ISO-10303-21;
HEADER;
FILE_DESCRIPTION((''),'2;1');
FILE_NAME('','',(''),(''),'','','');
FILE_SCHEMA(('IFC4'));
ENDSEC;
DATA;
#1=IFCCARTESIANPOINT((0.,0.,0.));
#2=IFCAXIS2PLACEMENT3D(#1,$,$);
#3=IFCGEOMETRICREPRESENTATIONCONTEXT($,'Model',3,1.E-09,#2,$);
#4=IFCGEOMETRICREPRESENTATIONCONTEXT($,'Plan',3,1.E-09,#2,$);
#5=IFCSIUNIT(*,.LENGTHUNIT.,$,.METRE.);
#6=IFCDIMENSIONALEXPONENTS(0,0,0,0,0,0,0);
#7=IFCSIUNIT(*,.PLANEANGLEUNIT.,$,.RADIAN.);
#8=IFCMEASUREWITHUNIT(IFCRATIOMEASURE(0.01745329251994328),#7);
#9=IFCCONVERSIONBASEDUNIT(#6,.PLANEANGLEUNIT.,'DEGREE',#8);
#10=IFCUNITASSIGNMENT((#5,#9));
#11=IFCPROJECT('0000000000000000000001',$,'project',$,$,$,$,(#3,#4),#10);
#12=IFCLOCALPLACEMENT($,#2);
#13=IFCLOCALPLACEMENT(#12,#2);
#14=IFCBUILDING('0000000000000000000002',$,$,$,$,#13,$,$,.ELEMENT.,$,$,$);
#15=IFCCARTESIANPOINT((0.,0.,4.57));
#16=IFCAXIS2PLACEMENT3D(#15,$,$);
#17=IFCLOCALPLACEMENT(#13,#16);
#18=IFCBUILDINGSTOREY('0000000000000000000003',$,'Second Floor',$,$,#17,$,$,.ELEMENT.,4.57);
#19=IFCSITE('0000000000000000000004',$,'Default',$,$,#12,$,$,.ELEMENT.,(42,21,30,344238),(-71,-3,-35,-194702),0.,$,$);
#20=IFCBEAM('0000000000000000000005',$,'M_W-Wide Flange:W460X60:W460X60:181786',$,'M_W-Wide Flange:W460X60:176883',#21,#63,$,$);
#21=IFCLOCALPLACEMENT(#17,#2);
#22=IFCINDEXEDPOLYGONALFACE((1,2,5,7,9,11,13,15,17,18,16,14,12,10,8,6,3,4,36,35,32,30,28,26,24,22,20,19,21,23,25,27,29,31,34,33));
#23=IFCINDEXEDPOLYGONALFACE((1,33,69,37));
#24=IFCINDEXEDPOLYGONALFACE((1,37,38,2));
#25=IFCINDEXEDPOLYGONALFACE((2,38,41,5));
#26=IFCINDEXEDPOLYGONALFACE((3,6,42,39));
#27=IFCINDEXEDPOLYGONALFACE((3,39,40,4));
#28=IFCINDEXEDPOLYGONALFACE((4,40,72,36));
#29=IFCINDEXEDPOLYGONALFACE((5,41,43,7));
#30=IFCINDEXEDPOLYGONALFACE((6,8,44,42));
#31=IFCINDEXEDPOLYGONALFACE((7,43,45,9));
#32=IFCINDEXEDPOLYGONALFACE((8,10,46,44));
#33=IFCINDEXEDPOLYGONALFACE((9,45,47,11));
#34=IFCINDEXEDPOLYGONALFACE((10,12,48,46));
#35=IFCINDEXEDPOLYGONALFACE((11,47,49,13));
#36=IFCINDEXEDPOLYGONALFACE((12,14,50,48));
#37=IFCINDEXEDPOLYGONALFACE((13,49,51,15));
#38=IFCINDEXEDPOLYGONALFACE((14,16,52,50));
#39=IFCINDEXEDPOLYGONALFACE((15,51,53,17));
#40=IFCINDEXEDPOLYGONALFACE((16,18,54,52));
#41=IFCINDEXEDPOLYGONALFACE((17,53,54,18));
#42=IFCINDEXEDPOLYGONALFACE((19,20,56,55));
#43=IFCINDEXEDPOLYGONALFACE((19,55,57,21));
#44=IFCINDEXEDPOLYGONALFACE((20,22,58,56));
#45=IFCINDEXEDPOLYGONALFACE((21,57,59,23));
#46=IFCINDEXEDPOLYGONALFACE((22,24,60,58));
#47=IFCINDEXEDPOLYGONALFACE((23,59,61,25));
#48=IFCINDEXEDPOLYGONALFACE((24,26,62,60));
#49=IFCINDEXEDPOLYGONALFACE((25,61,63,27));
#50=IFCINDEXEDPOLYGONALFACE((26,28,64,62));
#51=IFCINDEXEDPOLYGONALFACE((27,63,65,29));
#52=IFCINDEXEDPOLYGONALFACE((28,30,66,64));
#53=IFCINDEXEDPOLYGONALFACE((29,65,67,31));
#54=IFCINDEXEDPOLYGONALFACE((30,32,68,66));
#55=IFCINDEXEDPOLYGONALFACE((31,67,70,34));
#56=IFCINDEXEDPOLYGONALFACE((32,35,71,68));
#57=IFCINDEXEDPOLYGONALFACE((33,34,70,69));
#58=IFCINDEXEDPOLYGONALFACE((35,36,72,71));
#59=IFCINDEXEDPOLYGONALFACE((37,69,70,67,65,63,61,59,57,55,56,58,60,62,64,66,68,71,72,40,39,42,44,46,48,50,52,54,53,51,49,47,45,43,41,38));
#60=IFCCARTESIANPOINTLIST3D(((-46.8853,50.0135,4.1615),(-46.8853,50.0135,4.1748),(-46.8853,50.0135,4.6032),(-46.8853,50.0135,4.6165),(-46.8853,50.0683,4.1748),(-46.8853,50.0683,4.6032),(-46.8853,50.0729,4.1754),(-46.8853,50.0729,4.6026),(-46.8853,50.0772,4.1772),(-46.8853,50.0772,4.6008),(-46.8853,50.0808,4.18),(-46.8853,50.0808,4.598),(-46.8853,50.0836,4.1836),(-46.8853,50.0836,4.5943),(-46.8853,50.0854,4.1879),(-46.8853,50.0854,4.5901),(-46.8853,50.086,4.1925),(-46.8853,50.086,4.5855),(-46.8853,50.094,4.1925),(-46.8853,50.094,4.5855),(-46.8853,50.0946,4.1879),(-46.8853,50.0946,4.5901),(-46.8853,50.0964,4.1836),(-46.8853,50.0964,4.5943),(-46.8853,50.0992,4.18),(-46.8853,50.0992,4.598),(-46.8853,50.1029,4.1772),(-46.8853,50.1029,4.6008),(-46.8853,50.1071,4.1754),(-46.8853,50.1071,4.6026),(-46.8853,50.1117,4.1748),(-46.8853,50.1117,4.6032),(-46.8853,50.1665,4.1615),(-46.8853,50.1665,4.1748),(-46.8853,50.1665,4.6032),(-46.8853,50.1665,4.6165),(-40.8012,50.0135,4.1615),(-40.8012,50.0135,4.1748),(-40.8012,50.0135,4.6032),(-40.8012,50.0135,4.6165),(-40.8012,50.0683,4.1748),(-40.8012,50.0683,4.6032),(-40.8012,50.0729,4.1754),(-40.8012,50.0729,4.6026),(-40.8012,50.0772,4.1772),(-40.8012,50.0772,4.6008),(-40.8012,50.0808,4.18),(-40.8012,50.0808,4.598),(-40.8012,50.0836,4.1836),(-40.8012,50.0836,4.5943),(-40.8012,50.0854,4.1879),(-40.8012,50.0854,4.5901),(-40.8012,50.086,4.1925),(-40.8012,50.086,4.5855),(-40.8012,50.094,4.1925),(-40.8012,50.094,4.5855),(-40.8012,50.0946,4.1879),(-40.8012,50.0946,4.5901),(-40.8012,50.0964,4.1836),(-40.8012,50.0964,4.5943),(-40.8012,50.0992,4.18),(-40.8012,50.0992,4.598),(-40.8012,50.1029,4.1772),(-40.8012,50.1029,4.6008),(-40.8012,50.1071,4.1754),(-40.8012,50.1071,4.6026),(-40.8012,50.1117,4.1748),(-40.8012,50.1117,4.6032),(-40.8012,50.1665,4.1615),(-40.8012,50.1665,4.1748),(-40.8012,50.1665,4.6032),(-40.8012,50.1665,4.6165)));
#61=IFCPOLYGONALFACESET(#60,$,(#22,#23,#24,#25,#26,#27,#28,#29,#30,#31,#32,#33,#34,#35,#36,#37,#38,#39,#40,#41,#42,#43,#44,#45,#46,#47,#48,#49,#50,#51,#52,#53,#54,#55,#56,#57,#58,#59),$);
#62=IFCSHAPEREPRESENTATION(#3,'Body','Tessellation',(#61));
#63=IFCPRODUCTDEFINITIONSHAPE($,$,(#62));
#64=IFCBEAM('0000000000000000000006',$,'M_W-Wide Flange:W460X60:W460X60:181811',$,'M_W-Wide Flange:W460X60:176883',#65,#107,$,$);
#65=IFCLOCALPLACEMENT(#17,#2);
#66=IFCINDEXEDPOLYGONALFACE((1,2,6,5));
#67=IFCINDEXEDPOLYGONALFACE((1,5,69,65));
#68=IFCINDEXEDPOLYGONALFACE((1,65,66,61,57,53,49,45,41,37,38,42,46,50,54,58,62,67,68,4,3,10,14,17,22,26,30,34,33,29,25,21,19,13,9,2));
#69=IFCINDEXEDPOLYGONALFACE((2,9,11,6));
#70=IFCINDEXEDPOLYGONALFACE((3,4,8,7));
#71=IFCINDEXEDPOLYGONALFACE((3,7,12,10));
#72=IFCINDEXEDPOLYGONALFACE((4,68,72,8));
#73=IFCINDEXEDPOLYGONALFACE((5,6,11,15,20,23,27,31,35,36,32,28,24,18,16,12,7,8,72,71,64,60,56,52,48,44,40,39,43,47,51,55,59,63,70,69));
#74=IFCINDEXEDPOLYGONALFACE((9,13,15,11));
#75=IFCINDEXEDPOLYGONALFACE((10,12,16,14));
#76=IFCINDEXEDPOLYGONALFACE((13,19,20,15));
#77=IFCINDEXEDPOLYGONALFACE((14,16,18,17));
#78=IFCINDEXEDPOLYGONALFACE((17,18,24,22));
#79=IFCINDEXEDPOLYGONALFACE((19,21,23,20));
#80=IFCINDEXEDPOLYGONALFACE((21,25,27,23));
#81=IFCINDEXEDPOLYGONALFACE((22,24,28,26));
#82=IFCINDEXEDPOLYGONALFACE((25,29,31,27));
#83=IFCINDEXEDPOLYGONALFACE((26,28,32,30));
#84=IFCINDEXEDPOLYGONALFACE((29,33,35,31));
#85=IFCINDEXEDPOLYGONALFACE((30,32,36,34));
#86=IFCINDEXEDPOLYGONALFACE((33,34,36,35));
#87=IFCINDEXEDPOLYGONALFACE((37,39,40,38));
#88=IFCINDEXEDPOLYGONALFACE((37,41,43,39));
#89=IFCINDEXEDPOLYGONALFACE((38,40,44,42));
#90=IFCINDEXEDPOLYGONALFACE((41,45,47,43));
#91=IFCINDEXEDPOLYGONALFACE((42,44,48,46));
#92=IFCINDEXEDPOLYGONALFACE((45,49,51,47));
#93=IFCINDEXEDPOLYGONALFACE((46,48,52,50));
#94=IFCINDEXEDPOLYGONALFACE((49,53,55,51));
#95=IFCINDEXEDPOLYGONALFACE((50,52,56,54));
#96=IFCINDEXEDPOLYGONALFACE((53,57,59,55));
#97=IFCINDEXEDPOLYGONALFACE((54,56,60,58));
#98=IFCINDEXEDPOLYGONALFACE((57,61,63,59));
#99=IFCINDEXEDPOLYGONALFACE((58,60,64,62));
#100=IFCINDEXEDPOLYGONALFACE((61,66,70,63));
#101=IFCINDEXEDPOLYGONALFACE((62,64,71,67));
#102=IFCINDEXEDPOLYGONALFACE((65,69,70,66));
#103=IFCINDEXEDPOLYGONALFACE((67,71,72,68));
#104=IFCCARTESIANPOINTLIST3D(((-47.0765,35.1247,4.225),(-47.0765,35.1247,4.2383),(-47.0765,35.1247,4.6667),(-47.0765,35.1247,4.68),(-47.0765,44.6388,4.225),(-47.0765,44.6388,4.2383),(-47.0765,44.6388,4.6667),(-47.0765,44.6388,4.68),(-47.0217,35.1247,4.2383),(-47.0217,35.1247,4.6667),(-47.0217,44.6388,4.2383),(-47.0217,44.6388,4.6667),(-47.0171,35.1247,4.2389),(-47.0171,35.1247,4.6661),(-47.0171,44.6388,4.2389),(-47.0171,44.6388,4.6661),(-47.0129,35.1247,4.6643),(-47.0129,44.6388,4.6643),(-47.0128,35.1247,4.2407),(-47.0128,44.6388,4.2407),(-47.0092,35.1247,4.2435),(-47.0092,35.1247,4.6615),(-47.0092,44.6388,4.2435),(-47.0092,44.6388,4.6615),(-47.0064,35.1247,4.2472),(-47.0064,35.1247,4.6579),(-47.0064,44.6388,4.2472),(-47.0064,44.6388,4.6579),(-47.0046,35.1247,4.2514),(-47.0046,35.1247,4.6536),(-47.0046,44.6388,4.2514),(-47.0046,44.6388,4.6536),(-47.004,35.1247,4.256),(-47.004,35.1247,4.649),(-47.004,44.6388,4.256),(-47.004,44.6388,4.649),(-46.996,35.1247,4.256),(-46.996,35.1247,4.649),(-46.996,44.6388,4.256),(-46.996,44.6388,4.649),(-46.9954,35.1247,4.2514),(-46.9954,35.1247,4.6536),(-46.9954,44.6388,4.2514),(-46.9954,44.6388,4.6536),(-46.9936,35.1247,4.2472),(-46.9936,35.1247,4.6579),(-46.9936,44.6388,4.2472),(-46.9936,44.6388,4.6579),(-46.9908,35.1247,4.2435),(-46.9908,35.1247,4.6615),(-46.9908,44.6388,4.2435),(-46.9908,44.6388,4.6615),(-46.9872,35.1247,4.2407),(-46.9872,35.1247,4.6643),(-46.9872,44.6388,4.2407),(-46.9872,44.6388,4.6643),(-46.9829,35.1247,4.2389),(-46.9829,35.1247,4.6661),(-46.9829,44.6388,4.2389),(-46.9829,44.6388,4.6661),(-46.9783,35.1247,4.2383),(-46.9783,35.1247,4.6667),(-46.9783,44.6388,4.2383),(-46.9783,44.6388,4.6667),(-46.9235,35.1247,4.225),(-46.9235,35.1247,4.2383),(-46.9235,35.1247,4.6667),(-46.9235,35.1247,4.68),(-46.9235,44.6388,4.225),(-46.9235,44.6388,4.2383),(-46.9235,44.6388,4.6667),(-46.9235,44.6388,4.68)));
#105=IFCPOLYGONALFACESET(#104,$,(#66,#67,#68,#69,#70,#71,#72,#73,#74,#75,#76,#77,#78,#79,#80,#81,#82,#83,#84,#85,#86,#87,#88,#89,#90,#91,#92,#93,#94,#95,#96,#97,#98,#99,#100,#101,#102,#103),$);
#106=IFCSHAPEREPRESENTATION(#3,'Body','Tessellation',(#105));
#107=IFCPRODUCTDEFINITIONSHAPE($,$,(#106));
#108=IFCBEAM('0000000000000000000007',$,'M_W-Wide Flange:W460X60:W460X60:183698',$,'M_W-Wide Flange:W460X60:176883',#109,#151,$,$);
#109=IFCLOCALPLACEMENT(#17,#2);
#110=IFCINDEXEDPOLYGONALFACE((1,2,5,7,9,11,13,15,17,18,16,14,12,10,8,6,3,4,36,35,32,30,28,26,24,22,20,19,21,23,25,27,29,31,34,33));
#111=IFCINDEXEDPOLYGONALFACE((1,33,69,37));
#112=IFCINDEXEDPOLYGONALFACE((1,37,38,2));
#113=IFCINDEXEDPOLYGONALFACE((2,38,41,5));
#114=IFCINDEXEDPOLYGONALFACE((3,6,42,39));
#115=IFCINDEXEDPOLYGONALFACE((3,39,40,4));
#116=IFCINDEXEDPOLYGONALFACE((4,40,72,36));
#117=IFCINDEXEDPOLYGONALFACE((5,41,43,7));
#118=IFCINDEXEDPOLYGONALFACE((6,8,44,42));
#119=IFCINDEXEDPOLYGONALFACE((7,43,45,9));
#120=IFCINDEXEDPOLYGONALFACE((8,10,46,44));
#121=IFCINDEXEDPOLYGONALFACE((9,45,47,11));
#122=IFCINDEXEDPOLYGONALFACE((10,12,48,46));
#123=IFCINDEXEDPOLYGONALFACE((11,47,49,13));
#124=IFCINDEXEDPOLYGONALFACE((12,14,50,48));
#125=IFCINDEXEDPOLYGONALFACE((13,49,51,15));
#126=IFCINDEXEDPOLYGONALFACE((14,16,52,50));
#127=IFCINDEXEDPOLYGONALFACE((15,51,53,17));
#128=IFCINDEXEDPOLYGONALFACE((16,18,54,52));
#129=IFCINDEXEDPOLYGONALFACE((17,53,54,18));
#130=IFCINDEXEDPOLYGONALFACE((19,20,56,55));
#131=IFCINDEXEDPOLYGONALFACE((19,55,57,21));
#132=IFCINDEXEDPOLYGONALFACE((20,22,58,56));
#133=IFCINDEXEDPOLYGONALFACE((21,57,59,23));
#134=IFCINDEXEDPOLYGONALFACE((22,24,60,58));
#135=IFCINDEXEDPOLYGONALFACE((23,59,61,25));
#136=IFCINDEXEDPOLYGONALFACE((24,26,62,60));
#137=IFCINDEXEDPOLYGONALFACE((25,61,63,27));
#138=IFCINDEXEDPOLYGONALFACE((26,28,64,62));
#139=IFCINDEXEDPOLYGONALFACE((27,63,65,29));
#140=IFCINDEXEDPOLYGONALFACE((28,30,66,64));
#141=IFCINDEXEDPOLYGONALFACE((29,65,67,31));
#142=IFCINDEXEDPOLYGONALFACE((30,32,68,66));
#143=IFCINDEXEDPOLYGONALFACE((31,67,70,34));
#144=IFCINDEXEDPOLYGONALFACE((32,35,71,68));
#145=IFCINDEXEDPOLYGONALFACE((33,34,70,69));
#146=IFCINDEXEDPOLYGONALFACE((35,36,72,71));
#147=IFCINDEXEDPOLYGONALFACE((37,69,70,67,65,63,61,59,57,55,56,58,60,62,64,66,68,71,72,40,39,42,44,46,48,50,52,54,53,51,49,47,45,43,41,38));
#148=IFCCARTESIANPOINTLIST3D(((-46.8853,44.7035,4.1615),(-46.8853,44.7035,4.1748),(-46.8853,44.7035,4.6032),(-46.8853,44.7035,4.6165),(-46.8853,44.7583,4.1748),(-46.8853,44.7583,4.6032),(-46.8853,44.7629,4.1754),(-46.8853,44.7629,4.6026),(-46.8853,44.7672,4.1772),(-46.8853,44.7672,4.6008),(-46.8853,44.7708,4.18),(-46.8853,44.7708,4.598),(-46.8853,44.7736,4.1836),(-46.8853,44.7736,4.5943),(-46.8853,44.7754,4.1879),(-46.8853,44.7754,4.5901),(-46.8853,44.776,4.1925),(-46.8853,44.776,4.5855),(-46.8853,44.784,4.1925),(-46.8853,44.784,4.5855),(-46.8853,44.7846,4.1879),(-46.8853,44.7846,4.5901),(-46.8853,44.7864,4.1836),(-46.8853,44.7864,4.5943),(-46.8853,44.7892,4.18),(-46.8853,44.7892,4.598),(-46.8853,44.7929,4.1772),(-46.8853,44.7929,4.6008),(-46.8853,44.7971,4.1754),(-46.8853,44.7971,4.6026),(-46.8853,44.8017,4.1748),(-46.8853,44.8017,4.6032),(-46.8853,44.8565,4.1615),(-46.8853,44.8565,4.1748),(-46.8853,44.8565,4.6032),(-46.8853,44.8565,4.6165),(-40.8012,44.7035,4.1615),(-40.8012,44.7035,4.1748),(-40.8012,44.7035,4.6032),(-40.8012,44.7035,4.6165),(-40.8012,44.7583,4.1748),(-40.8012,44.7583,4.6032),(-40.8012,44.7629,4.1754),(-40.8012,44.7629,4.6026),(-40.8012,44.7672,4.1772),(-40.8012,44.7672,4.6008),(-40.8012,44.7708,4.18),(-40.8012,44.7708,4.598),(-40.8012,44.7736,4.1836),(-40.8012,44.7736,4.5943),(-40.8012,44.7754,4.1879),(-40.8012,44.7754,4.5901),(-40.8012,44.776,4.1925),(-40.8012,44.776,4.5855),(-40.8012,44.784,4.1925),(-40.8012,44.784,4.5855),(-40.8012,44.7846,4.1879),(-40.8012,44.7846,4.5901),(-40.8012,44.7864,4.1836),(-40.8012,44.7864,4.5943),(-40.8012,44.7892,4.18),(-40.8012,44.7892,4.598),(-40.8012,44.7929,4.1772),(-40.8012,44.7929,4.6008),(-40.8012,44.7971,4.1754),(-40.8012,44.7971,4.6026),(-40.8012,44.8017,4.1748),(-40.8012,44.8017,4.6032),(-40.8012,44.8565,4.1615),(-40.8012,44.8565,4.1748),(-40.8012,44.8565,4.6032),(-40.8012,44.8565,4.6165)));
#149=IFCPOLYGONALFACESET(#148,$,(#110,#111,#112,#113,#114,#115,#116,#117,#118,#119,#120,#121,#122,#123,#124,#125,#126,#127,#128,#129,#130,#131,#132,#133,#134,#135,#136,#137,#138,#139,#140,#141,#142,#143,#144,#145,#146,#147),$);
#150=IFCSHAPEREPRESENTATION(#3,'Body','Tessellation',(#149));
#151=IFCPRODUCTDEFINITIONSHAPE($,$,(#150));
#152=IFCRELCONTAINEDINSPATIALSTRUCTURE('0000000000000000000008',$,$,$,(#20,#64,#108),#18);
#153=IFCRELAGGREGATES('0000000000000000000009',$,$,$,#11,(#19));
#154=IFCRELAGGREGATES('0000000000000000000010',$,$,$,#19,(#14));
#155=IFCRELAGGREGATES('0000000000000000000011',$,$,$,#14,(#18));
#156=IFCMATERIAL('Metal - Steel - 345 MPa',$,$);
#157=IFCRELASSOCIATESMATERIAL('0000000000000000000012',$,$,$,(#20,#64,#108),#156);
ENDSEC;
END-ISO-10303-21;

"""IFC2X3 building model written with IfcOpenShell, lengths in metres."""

from ifc_helpers import new_model, entity, si_unit, converted_unit, frame, frame_2d, origin, place, context, project, spatial, polyline, circle_curve, parameter, trimmed, segment, composite_curve, outline, extrude, material, element, save


model = new_model("IFC2X3")

# Units and contexts
model_context = context("Model", 3, precision=1e-09, world=origin())
plan_context = context("Plan", 3, precision=1e-09, world=origin())
ifc_project = project(units=[si_unit("LENGTHUNIT", "METRE"), converted_unit("PLANEANGLEUNIT", "DEGREE", entity("IfcRatioMeasure", 0.01745329251994328), si_unit("PLANEANGLEUNIT", "RADIAN"), dimensions=[0, 0, 0, 0, 0, 0, 0])], contexts=[model_context, plan_context])

# Site, building, storey
site_placement = place(None, origin())
site = spatial("IfcSite", under=ifc_project, at=site_placement, Name="Default", CompositionType="ELEMENT", RefLatitude=(42, 21, 30, 344238), RefLongitude=(-71, -3, -35, -194702), RefElevation=0.0)
building_placement = place(site_placement, origin())
building = spatial("IfcBuilding", under=site, at=building_placement, CompositionType="ELEMENT")
storey_placement = place(building_placement, frame((0.0, 0.0, 4.57)))
storey = spatial("IfcBuildingStorey", under=building, at=storey_placement, Name="Second Floor", CompositionType="ELEMENT", Elevation=4.57)

# Shared definitions
ifc_material_1 = material(Name="Metal - Steel - 345 MPa")

# Beams
beam_1_placement = place(storey_placement, frame((-40.6613, 50.09, 4.6165), z_axis=(0.0, 0.0, 1.0), x_axis=(0.0, 1.0, 0.0)))
element("IfcBeam", 1, at=beam_1_placement, inside=storey, material=ifc_material_1, Name="M_W-Wide Flange:W460X60:W460X60:181786", ObjectType="M_W-Wide Flange:W460X60:176883", context=model_context, shape_type="SweptSolid", body=[
    extrude(outline(composite_curve([segment(polyline([(0.2142, -0.0765), (0.2275, -0.0765)]), True, "CONTINUOUS"), segment(polyline([(0.2275, -0.0765), (0.2275, 0.0765)]), True, "CONTINUOUS"), segment(polyline([(0.2275, 0.0765), (0.2142, 0.0765)]), True, "CONTINUOUS"), segment(polyline([(0.2142, 0.0765), (0.2142, 0.0217)]), True, "CONTINUOUS"), segment(trimmed(circle_curve(frame_2d((0.1965, 0.0217), x_axis=(0.0, 1.0)), 0.0177), [parameter(180.0)], [parameter(270.0)], True, "PARAMETER"), False, "CONTINUOUS"), segment(polyline([(0.1965, 0.004), (-0.1965, 0.004)]), True, "CONTINUOUS"), segment(trimmed(circle_curve(frame_2d((-0.1965, 0.0217), x_axis=(0.0, 1.0)), 0.0177), [parameter(90.0)], [parameter(180.0)], True, "PARAMETER"), False, "CONTINUOUS"), segment(polyline([(-0.2142, 0.0217), (-0.2142, 0.0765)]), True, "CONTINUOUS"), segment(polyline([(-0.2142, 0.0765), (-0.2275, 0.0765)]), True, "CONTINUOUS"), segment(polyline([(-0.2275, 0.0765), (-0.2275, -0.0765)]), True, "CONTINUOUS"), segment(polyline([(-0.2275, -0.0765), (-0.2142, -0.0765)]), True, "CONTINUOUS"), segment(polyline([(-0.2142, -0.0765), (-0.2142, -0.0217)]), True, "CONTINUOUS"), segment(trimmed(circle_curve(frame_2d((-0.1965, -0.0217), x_axis=(0.0, 1.0)), 0.0177), [parameter(360.0)], [parameter(90.0)], True, "PARAMETER"), False, "CONTINUOUS"), segment(polyline([(-0.1965, -0.004), (0.1965, -0.004)]), True, "CONTINUOUS"), segment(trimmed(circle_curve(frame_2d((0.1965, -0.0217), x_axis=(0.0, 1.0)), 0.0177), [parameter(270.0)], [parameter(0.0)], True, "PARAMETER"), False, "CONTINUOUS"), segment(polyline([(0.2142, -0.0217), (0.2142, -0.0765)]), True, "CONTINUOUS")], self_intersect=False)), frame((0.0, 6.224, -0.2275), z_axis=(0.0, -1.0, 0.0), x_axis=(0.0, 0.0, -1.0)), (0.0, 0.0, 1.0), 6.0841),
])
beam_2_placement = place(storey_placement, frame((-47.0, 44.7781, 4.68), z_axis=(0.0, 0.0, 1.0), x_axis=(-1.0, 0.0, 0.0)))
element("IfcBeam", 2, at=beam_2_placement, inside=storey, material=ifc_material_1, Name="M_W-Wide Flange:W460X60:W460X60:181811", ObjectType="M_W-Wide Flange:W460X60:176883", context=model_context, shape_type="SweptSolid", body=[
    extrude(outline(composite_curve([segment(polyline([(0.2142, -0.0765), (0.2275, -0.0765)]), True, "CONTINUOUS"), segment(polyline([(0.2275, -0.0765), (0.2275, 0.0765)]), True, "CONTINUOUS"), segment(polyline([(0.2275, 0.0765), (0.2142, 0.0765)]), True, "CONTINUOUS"), segment(polyline([(0.2142, 0.0765), (0.2142, 0.0217)]), True, "CONTINUOUS"), segment(trimmed(circle_curve(frame_2d((0.1965, 0.0217), x_axis=(1.0, 0.0)), 0.0177), [parameter(270.0)], [parameter(360.0)], True, "PARAMETER"), False, "CONTINUOUS"), segment(polyline([(0.1965, 0.004), (-0.1965, 0.004)]), True, "CONTINUOUS"), segment(trimmed(circle_curve(frame_2d((-0.1965, 0.0217), x_axis=(0.0, -1.0)), 0.0177), [parameter(270.0)], [parameter(360.0)], True, "PARAMETER"), False, "CONTINUOUS"), segment(polyline([(-0.2142, 0.0217), (-0.2142, 0.0765)]), True, "CONTINUOUS"), segment(polyline([(-0.2142, 0.0765), (-0.2275, 0.0765)]), True, "CONTINUOUS"), segment(polyline([(-0.2275, 0.0765), (-0.2275, -0.0765)]), True, "CONTINUOUS"), segment(polyline([(-0.2275, -0.0765), (-0.2142, -0.0765)]), True, "CONTINUOUS"), segment(polyline([(-0.2142, -0.0765), (-0.2142, -0.0217)]), True, "CONTINUOUS"), segment(trimmed(circle_curve(frame_2d((-0.1965, -0.0217), x_axis=(-1.0, 0.0)), 0.0177), [parameter(270.0)], [parameter(360.0)], True, "PARAMETER"), False, "CONTINUOUS"), segment(polyline([(-0.1965, -0.004), (0.1965, -0.004)]), True, "CONTINUOUS"), segment(trimmed(circle_curve(frame_2d((0.1965, -0.0217), x_axis=(0.0, 1.0)), 0.0177), [parameter(270.0)], [parameter(0.0)], True, "PARAMETER"), False, "CONTINUOUS"), segment(polyline([(0.2142, -0.0217), (0.2142, -0.0765)]), True, "CONTINUOUS")], self_intersect=False)), frame((0.0, 9.6534, -0.2275), z_axis=(0.0, -1.0, 0.0), x_axis=(0.0, 0.0, -1.0)), (0.0, 0.0, 1.0), 9.5141),
])
beam_3_placement = place(storey_placement, frame((-46.997, 44.78, 4.6165), z_axis=(0.0, 0.0, 1.0), x_axis=(0.0, -1.0, 0.0)))
element("IfcBeam", 3, at=beam_3_placement, inside=storey, material=ifc_material_1, Name="M_W-Wide Flange:W460X60:W460X60:183698", ObjectType="M_W-Wide Flange:W460X60:176883", context=model_context, shape_type="SweptSolid", body=[
    extrude(outline(composite_curve([segment(polyline([(-0.0765, -0.2142), (-0.0765, -0.2275)]), True, "CONTINUOUS"), segment(polyline([(-0.0765, -0.2275), (0.0765, -0.2275)]), True, "CONTINUOUS"), segment(polyline([(0.0765, -0.2275), (0.0765, -0.2142)]), True, "CONTINUOUS"), segment(polyline([(0.0765, -0.2142), (0.0217, -0.2142)]), True, "CONTINUOUS"), segment(trimmed(circle_curve(frame_2d((0.0217, -0.1965), x_axis=(0.0, -1.0)), 0.0177), [parameter(270.0)], [parameter(360.0)], True, "PARAMETER"), False, "CONTINUOUS"), segment(polyline([(0.004, -0.1965), (0.004, 0.1965)]), True, "CONTINUOUS"), segment(trimmed(circle_curve(frame_2d((0.0217, 0.1965), x_axis=(-1.0, 0.0)), 0.0177), [parameter(270.0)], [parameter(360.0)], True, "PARAMETER"), False, "CONTINUOUS"), segment(polyline([(0.0217, 0.2142), (0.0765, 0.2142)]), True, "CONTINUOUS"), segment(polyline([(0.0765, 0.2142), (0.0765, 0.2275)]), True, "CONTINUOUS"), segment(polyline([(0.0765, 0.2275), (-0.0765, 0.2275)]), True, "CONTINUOUS"), segment(polyline([(-0.0765, 0.2275), (-0.0765, 0.2142)]), True, "CONTINUOUS"), segment(polyline([(-0.0765, 0.2142), (-0.0217, 0.2142)]), True, "CONTINUOUS"), segment(trimmed(circle_curve(frame_2d((-0.0217, 0.1965), x_axis=(0.0, 1.0)), 0.0177), [parameter(270.0)], [parameter(360.0)], True, "PARAMETER"), False, "CONTINUOUS"), segment(polyline([(-0.004, 0.1965), (-0.004, -0.1965)]), True, "CONTINUOUS"), segment(trimmed(circle_curve(frame_2d((-0.0217, -0.1965), x_axis=(1.0, 0.0)), 0.0177), [parameter(270.0)], [parameter(0.0)], True, "PARAMETER"), False, "CONTINUOUS"), segment(polyline([(-0.0217, -0.2142), (-0.0765, -0.2142)]), True, "CONTINUOUS")], self_intersect=False)), frame((0.0, 0.1117, -0.2275), z_axis=(0.0, -1.0, 0.0), x_axis=(1.0, 0.0, 0.0)), (0.0, 0.0, -1.0), 6.0841),
])

save(model, "model.ifc")
